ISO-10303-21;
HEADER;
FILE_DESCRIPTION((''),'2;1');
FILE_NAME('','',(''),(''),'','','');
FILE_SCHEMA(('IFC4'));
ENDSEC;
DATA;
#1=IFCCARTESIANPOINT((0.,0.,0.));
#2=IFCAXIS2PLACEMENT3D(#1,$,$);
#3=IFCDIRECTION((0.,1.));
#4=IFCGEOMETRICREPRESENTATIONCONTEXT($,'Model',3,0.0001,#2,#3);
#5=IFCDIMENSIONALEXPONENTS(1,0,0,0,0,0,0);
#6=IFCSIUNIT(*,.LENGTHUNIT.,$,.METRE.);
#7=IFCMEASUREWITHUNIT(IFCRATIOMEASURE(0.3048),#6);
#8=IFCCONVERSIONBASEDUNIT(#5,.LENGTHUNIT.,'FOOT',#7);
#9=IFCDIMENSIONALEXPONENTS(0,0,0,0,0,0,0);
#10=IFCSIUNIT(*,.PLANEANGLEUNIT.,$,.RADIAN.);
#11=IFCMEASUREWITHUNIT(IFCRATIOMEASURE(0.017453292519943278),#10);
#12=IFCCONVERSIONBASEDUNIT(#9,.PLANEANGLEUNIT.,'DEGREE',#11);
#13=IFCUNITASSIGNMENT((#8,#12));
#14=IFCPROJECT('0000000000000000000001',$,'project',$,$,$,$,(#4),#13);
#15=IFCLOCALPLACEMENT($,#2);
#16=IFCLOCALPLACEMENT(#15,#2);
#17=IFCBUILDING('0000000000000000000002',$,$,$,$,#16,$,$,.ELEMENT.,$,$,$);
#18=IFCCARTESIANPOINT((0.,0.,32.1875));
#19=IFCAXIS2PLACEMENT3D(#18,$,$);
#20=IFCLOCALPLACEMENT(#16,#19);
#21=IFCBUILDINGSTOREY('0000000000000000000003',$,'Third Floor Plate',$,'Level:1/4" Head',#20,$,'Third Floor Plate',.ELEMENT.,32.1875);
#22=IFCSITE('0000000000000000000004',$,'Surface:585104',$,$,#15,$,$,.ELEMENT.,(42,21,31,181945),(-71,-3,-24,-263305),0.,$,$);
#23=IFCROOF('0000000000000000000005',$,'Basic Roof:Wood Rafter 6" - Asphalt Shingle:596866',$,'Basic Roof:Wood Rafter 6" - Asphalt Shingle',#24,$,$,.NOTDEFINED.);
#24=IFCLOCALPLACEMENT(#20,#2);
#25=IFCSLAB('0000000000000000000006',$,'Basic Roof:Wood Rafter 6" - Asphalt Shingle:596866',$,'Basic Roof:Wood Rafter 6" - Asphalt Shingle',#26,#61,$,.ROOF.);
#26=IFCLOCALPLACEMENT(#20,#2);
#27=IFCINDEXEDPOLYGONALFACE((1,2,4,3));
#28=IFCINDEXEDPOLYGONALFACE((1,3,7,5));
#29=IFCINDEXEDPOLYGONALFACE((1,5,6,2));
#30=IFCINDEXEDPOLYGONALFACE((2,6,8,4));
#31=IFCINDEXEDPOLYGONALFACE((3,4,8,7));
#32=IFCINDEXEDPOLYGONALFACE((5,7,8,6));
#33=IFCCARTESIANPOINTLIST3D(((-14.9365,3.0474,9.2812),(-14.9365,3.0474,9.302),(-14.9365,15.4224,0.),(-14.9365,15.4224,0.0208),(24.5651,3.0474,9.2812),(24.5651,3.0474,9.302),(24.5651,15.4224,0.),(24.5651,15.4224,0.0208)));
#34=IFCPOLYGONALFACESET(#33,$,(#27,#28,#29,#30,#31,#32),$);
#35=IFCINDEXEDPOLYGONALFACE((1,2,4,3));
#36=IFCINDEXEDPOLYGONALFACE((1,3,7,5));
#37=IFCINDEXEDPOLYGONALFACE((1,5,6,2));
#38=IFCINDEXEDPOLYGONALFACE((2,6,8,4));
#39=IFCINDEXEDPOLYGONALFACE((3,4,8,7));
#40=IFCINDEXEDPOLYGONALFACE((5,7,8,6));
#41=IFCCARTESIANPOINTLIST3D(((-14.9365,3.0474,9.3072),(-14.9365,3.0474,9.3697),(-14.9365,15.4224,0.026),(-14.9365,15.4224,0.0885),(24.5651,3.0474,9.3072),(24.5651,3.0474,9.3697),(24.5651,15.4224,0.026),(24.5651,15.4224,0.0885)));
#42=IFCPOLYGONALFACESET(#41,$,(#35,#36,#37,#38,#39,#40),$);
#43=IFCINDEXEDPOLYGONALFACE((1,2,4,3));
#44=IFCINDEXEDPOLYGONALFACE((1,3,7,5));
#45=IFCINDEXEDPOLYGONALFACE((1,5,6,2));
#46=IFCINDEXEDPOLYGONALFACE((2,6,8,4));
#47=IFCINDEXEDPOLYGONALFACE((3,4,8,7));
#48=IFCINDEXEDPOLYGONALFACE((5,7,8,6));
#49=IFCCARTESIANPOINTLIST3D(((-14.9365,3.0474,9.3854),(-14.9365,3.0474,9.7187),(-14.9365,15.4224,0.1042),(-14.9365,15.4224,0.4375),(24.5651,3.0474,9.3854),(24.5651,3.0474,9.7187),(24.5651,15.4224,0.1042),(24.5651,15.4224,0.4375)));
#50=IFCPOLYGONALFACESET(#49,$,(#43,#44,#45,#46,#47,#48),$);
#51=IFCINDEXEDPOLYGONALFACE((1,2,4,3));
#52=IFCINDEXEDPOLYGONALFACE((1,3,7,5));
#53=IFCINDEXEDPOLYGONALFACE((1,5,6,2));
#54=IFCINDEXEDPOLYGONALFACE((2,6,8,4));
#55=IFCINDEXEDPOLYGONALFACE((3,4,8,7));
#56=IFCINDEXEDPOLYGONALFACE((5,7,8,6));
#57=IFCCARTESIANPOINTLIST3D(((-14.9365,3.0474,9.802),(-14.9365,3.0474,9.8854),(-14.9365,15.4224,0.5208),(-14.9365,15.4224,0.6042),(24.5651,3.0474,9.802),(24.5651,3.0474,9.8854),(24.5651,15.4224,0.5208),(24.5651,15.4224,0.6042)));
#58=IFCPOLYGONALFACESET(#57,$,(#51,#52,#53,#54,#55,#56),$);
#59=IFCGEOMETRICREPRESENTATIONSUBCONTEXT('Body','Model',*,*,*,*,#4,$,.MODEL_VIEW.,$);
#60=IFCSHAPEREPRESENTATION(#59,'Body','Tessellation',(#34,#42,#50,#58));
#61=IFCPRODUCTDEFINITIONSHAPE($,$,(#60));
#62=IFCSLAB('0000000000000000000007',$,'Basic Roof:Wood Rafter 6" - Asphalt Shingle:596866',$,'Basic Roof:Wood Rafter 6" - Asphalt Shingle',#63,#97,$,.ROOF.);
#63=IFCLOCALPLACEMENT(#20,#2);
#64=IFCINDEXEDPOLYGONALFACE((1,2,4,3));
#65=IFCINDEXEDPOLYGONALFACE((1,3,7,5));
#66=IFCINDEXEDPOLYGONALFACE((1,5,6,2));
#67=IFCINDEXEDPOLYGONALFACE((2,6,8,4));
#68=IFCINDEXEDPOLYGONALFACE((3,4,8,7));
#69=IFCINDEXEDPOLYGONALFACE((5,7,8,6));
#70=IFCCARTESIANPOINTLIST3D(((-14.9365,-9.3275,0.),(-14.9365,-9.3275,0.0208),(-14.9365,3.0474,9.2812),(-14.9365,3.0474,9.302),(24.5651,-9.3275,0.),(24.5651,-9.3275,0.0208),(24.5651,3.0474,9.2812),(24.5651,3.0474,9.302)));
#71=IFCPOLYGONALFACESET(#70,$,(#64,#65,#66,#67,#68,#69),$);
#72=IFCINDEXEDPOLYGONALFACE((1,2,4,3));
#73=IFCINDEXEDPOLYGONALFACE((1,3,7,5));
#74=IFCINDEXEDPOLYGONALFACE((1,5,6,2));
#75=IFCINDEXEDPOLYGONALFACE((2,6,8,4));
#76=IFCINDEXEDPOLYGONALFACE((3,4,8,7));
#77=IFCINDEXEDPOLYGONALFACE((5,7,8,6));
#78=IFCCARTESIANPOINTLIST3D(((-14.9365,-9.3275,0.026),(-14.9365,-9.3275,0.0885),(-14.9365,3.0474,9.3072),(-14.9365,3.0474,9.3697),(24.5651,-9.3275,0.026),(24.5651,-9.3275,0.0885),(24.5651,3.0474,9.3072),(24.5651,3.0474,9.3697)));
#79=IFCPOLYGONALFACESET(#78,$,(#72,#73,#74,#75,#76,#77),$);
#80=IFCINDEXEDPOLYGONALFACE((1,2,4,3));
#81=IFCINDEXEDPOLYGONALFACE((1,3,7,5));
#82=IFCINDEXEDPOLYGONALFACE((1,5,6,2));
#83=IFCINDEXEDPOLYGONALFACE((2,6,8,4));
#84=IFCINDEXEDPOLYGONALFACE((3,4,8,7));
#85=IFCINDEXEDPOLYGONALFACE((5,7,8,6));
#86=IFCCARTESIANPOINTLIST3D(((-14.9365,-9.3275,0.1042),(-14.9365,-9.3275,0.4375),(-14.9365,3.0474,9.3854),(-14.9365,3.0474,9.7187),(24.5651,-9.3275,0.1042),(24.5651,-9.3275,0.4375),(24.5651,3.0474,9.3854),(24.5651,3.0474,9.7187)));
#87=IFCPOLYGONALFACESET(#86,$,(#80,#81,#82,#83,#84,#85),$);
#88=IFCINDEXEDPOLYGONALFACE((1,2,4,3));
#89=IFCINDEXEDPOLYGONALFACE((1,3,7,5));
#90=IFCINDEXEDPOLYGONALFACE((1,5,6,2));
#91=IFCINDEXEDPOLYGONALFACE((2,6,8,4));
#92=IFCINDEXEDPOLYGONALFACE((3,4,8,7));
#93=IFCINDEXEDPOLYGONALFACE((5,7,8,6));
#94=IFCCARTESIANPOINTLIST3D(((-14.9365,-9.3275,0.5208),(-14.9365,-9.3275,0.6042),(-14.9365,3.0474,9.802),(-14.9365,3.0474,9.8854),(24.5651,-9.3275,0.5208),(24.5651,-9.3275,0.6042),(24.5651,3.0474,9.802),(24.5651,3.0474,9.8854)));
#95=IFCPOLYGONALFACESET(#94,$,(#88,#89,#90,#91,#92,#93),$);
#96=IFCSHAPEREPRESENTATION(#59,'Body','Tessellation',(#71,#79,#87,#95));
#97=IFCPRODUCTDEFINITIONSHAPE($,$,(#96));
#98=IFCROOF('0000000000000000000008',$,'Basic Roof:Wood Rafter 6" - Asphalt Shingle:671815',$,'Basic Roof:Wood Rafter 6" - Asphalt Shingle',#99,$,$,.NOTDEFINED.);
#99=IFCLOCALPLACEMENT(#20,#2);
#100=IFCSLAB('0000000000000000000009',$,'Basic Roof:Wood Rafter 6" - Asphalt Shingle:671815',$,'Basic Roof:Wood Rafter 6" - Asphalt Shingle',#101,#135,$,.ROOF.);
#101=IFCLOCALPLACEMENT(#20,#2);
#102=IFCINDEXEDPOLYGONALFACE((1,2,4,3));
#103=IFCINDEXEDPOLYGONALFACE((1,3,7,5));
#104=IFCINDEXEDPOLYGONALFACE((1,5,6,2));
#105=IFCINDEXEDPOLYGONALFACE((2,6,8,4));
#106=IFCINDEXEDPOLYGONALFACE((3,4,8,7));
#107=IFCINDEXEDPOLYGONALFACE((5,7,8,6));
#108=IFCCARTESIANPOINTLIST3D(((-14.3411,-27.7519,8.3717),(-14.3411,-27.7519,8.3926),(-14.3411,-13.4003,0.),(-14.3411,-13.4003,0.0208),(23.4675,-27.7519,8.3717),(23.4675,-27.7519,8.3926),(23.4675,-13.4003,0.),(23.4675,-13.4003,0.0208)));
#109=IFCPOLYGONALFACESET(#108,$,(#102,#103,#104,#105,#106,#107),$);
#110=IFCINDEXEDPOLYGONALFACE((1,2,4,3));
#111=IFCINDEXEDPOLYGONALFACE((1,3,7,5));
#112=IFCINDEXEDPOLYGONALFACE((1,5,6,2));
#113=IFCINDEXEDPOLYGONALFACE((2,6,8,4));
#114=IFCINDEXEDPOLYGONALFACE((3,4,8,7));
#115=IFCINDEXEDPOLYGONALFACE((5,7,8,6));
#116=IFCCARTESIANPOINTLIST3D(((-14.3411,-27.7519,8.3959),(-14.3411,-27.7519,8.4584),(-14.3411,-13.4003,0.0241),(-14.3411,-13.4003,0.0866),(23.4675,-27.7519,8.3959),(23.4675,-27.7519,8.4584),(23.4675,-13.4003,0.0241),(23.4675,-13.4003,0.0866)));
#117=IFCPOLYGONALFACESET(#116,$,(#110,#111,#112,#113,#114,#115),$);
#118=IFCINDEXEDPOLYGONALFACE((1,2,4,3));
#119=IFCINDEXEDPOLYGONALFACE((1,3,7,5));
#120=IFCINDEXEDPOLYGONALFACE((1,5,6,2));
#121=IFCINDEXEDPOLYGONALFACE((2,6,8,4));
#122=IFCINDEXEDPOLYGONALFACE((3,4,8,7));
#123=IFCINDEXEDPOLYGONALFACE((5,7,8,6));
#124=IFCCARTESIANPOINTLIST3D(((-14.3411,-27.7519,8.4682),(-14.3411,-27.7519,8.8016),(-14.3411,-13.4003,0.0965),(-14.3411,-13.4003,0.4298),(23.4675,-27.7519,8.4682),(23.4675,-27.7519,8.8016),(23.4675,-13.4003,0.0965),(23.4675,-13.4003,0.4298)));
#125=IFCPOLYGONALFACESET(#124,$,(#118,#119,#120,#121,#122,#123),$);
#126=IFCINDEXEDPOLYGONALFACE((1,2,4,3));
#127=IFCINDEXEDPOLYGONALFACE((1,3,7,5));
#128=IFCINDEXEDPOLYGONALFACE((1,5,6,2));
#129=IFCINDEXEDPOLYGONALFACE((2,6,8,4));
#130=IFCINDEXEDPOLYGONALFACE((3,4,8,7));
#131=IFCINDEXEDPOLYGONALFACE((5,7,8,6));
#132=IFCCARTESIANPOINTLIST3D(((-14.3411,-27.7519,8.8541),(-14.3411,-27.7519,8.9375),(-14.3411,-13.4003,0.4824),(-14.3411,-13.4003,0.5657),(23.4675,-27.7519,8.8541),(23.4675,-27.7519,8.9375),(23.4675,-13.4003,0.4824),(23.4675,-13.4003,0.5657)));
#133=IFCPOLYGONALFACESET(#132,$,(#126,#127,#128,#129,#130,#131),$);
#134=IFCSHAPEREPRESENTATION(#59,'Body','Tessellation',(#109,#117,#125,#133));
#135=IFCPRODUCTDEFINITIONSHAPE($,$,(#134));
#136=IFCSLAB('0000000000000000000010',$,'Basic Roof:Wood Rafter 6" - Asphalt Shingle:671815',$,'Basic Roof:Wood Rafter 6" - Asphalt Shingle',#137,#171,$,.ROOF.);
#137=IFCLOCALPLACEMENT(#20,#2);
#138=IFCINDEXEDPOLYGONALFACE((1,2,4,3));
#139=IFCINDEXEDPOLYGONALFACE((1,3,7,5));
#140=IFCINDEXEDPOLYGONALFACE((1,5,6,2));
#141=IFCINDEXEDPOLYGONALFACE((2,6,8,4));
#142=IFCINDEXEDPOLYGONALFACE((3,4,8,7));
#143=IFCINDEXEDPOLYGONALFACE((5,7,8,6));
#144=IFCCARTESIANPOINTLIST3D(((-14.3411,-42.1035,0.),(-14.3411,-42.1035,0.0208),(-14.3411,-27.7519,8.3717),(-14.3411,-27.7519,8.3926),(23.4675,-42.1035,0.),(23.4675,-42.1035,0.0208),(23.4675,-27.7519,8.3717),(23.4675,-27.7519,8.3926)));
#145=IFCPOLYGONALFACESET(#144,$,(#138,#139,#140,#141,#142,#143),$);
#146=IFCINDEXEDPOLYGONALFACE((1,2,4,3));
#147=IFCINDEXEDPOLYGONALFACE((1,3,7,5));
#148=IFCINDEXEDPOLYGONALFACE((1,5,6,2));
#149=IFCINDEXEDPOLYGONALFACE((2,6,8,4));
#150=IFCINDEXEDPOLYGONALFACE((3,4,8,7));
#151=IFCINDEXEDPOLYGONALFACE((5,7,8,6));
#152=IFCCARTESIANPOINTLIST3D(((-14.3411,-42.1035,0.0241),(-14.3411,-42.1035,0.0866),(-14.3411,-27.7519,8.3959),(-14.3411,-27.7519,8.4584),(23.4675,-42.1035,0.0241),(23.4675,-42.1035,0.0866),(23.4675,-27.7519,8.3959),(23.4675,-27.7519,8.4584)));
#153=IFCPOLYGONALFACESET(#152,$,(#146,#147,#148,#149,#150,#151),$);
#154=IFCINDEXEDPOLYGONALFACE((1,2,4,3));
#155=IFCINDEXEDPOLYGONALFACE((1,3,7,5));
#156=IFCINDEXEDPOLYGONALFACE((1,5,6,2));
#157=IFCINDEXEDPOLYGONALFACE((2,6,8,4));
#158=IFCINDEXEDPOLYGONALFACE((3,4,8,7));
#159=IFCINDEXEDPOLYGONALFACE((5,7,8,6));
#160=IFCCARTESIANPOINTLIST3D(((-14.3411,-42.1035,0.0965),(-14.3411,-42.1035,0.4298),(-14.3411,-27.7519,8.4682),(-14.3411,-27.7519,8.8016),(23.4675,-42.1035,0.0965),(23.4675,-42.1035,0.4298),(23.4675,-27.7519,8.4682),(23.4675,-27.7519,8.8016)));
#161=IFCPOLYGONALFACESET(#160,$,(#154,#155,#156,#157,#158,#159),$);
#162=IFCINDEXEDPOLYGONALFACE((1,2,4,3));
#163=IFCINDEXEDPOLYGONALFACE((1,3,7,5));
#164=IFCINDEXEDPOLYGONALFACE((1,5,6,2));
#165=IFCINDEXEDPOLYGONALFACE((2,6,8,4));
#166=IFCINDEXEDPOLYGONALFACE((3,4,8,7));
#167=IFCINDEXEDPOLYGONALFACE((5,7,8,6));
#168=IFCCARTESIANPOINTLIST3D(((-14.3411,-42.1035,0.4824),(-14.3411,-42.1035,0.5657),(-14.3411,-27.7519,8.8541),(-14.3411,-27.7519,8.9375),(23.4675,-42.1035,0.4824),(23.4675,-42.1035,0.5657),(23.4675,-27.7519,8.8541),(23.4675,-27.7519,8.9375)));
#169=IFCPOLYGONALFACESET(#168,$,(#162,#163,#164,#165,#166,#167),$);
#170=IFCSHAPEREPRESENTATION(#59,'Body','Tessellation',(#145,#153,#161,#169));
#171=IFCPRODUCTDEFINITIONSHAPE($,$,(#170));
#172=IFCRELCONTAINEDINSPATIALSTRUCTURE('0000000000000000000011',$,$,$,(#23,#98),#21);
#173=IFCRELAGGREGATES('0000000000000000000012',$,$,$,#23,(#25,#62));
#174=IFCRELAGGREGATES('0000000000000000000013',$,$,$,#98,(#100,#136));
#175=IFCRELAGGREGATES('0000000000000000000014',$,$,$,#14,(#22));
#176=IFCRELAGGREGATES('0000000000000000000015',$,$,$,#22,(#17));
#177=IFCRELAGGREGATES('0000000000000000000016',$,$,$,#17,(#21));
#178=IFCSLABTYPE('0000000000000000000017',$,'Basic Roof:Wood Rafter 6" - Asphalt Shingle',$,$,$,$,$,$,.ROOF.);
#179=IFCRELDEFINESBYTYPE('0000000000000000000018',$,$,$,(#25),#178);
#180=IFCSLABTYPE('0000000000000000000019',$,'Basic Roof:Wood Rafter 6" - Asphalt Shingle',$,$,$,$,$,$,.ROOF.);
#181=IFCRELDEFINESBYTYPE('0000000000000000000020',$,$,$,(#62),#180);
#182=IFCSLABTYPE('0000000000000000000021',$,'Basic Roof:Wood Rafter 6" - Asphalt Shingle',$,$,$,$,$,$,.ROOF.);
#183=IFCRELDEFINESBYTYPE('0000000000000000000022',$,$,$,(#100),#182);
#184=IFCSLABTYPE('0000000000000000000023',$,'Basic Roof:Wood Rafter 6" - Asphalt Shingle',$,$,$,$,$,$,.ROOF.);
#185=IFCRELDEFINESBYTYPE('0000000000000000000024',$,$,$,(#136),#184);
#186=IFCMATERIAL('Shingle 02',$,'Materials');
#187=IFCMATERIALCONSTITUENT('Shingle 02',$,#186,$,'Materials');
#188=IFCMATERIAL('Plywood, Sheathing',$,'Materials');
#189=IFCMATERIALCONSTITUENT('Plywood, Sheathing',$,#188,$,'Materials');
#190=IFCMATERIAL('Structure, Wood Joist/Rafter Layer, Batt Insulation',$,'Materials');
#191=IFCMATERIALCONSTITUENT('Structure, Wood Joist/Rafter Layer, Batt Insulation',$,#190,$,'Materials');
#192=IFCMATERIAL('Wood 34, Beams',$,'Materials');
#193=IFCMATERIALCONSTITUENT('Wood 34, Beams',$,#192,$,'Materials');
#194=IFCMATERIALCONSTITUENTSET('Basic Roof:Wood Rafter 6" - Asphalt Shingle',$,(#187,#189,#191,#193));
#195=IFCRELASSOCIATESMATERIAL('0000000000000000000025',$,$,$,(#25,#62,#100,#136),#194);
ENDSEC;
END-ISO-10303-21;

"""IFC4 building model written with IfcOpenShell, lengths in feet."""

from ifc_helpers import new_model, entity, si_unit, converted_unit, direction, frame, origin, place, context, subcontext, project, spatial, indexed_curve, outline, extrude, material, constituent, constituent_set, type_object, element, aggregate, save


model = new_model("IFC4")

# Units and contexts
model_context = context("Model", 3, precision=0.0001, world=origin(), true_north=direction((0.0, 1.0)))
body_context = subcontext(model_context, "Body", "Model", "MODEL_VIEW")
ifc_project = project(units=[converted_unit("LENGTHUNIT", "FOOT", entity("IfcRatioMeasure", 0.3048), si_unit("LENGTHUNIT", "METRE"), dimensions=[1, 0, 0, 0, 0, 0, 0]), converted_unit("PLANEANGLEUNIT", "DEGREE", entity("IfcRatioMeasure", 0.017453292519943278), si_unit("PLANEANGLEUNIT", "RADIAN"), dimensions=[0, 0, 0, 0, 0, 0, 0])], contexts=[model_context])

# Site, building, storey
site_placement = place(None, origin())
site = spatial("IfcSite", under=ifc_project, at=site_placement, Name="Surface:585104", CompositionType="ELEMENT", RefLatitude=(42, 21, 31, 181945), RefLongitude=(-71, -3, -24, -263305), RefElevation=0.0)
building_placement = place(site_placement, origin())
building = spatial("IfcBuilding", under=site, at=building_placement, CompositionType="ELEMENT")
storey_placement = place(building_placement, frame((0.0, 0.0, 32.1875)))
storey = spatial("IfcBuildingStorey", under=building, at=storey_placement, Name="Third Floor Plate", ObjectType="Level:1/4\" Head", LongName="Third Floor Plate", CompositionType="ELEMENT", Elevation=32.1875)

# Roofs, slabs
roof_1_placement = place(storey_placement, frame((-14.9365, -9.3275, 0.0)))
roof_1 = element("IfcRoof", 1, at=roof_1_placement, inside=storey, Name="Basic Roof:Wood Rafter 6\" - Asphalt Shingle:596866", ObjectType="Basic Roof:Wood Rafter 6\" - Asphalt Shingle", PredefinedType="NOTDEFINED")
ifc_material_1 = material(Name="Shingle 02", Category="Materials")
ifc_constituent_1 = constituent(ifc_material_1, Name="Shingle 02", Category="Materials")
ifc_material_2 = material(Name="Plywood, Sheathing", Category="Materials")
ifc_constituent_2 = constituent(ifc_material_2, Name="Plywood, Sheathing", Category="Materials")
ifc_material_3 = material(Name="Structure, Wood Joist/Rafter Layer, Batt Insulation", Category="Materials")
ifc_constituent_3 = constituent(ifc_material_3, Name="Structure, Wood Joist/Rafter Layer, Batt Insulation", Category="Materials")
ifc_material_4 = material(Name="Wood 34, Beams", Category="Materials")
ifc_constituent_4 = constituent(ifc_material_4, Name="Wood 34, Beams", Category="Materials")
ifc_constituent_set_1 = constituent_set(constituents=[ifc_constituent_1, ifc_constituent_2, ifc_constituent_3, ifc_constituent_4], Name="Basic Roof:Wood Rafter 6\" - Asphalt Shingle")
slab_type_1 = type_object("IfcSlabType", Name="Basic Roof:Wood Rafter 6\" - Asphalt Shingle", PredefinedType="ROOF")
slab_1_placement = place(roof_1_placement, origin())
slab_1 = element("IfcSlab", 2, at=slab_1_placement, type_object=slab_type_1, material=ifc_constituent_set_1, Name="Basic Roof:Wood Rafter 6\" - Asphalt Shingle:596866", ObjectType="Basic Roof:Wood Rafter 6\" - Asphalt Shingle", PredefinedType="ROOF", context=body_context, shape_type="SweptSolid", body=[
    extrude(outline(indexed_curve([(-19.7508, 7.7343), (-19.7508, -7.7343), (19.7508, -7.7343), (19.7508, 7.7343), (-19.7508, 7.7343)], self_intersect=False)), frame((19.7508, 18.5624, 4.6406), z_axis=(0.0, 0.6, 0.8), x_axis=(1.0, 0.0, 0.0)), (0.0, -0.6, 0.8), 0.0208),
    extrude(outline(indexed_curve([(-19.7508, 7.7343), (-19.7508, -7.7343), (19.7508, -7.7343), (19.7508, 7.7343), (-19.7508, 7.7343)], self_intersect=False)), frame((19.7508, 18.5624, 4.6666), z_axis=(0.0, 0.6, 0.8), x_axis=(1.0, 0.0, 0.0)), (0.0, -0.6, 0.8), 0.0625),
    extrude(outline(indexed_curve([(-19.7508, 7.7343), (-19.7508, -7.7343), (19.7508, -7.7343), (19.7508, 7.7343), (-19.7508, 7.7343)], self_intersect=False)), frame((19.7508, 18.5624, 4.7448), z_axis=(0.0, 0.6, 0.8), x_axis=(1.0, 0.0, 0.0)), (0.0, -0.6, 0.8), 0.3333),
    extrude(outline(indexed_curve([(-19.7508, 7.7343), (-19.7508, -7.7343), (19.7508, -7.7343), (19.7508, 7.7343), (-19.7508, 7.7343)], self_intersect=False)), frame((19.7508, 18.5624, 5.1614), z_axis=(0.0, 0.6, 0.8), x_axis=(1.0, 0.0, 0.0)), (0.0, -0.6, 0.8), 0.0833),
])
slab_type_2 = type_object("IfcSlabType", Name="Basic Roof:Wood Rafter 6\" - Asphalt Shingle", PredefinedType="ROOF")
slab_2_placement = place(roof_1_placement, origin())
slab_2 = element("IfcSlab", 3, at=slab_2_placement, type_object=slab_type_2, material=ifc_constituent_set_1, Name="Basic Roof:Wood Rafter 6\" - Asphalt Shingle:596866", ObjectType="Basic Roof:Wood Rafter 6\" - Asphalt Shingle", PredefinedType="ROOF", context=body_context, shape_type="SweptSolid", body=[
    extrude(outline(indexed_curve([(19.7508, 7.7343), (-19.7508, 7.7343), (-19.7508, -7.7343), (19.7508, -7.7343), (19.7508, 7.7343)], self_intersect=False)), frame((19.7508, 6.1875, 4.6406), z_axis=(0.0, -0.6, 0.8), x_axis=(1.0, 0.0, 0.0)), (0.0, 0.6, 0.8), 0.0208),
    extrude(outline(indexed_curve([(19.7508, 7.7343), (-19.7508, 7.7343), (-19.7508, -7.7343), (19.7508, -7.7343), (19.7508, 7.7343)], self_intersect=False)), frame((19.7508, 6.1875, 4.6666), z_axis=(0.0, -0.6, 0.8), x_axis=(1.0, 0.0, 0.0)), (0.0, 0.6, 0.8), 0.0625),
    extrude(outline(indexed_curve([(19.7508, 7.7343), (-19.7508, 7.7343), (-19.7508, -7.7343), (19.7508, -7.7343), (19.7508, 7.7343)], self_intersect=False)), frame((19.7508, 6.1875, 4.7448), z_axis=(0.0, -0.6, 0.8), x_axis=(1.0, 0.0, 0.0)), (0.0, 0.6, 0.8), 0.3333),
    extrude(outline(indexed_curve([(19.7508, 7.7343), (-19.7508, 7.7343), (-19.7508, -7.7343), (19.7508, -7.7343), (19.7508, 7.7343)], self_intersect=False)), frame((19.7508, 6.1875, 5.1614), z_axis=(0.0, -0.6, 0.8), x_axis=(1.0, 0.0, 0.0)), (0.0, 0.6, 0.8), 0.0833),
])
aggregate(roof_1, [slab_1, slab_2])
roof_2_placement = place(storey_placement, frame((-14.3411, -42.1035, 0.0)))
roof_2 = element("IfcRoof", 4, at=roof_2_placement, inside=storey, Name="Basic Roof:Wood Rafter 6\" - Asphalt Shingle:671815", ObjectType="Basic Roof:Wood Rafter 6\" - Asphalt Shingle", PredefinedType="NOTDEFINED")
slab_type_3 = type_object("IfcSlabType", Name="Basic Roof:Wood Rafter 6\" - Asphalt Shingle", PredefinedType="ROOF")
slab_3_placement = place(roof_2_placement, origin())
slab_3 = element("IfcSlab", 5, at=slab_3_placement, type_object=slab_type_3, material=ifc_constituent_set_1, Name="Basic Roof:Wood Rafter 6\" - Asphalt Shingle:671815", ObjectType="Basic Roof:Wood Rafter 6\" - Asphalt Shingle", PredefinedType="ROOF", context=body_context, shape_type="SweptSolid", body=[
    extrude(outline(indexed_curve([(-18.9043, 8.3074), (-18.9043, -8.3074), (18.9043, -8.3074), (18.9043, 8.3074), (-18.9043, 8.3074)], self_intersect=False)), frame((18.9043, 21.5273, 4.1859), z_axis=(0.0, 0.503871, 0.863779), x_axis=(1.0, 0.0, 0.0)), (0.0, -0.503871, 0.863779), 0.0208),
    extrude(outline(indexed_curve([(-18.9043, 8.3074), (-18.9043, -8.3074), (18.9043, -8.3074), (18.9043, 8.3074), (-18.9043, 8.3074)], self_intersect=False)), frame((18.9043, 21.5273, 4.21), z_axis=(0.0, 0.503871, 0.863779), x_axis=(1.0, 0.0, 0.0)), (0.0, -0.503871, 0.863779), 0.0625),
    extrude(outline(indexed_curve([(-18.9043, 8.3074), (-18.9043, -8.3074), (18.9043, -8.3074), (18.9043, 8.3074), (-18.9043, 8.3074)], self_intersect=False)), frame((18.9043, 21.5273, 4.2823), z_axis=(0.0, 0.503871, 0.863779), x_axis=(1.0, 0.0, 0.0)), (0.0, -0.503871, 0.863779), 0.3333),
    extrude(outline(indexed_curve([(-18.9043, 8.3074), (-18.9043, -8.3074), (18.9043, -8.3074), (18.9043, 8.3074), (-18.9043, 8.3074)], self_intersect=False)), frame((18.9043, 21.5273, 4.6682), z_axis=(0.0, 0.503871, 0.863779), x_axis=(1.0, 0.0, 0.0)), (0.0, -0.503871, 0.863779), 0.0833),
])
slab_type_4 = type_object("IfcSlabType", Name="Basic Roof:Wood Rafter 6\" - Asphalt Shingle", PredefinedType="ROOF")
slab_4_placement = place(roof_2_placement, origin())
slab_4 = element("IfcSlab", 6, at=slab_4_placement, type_object=slab_type_4, material=ifc_constituent_set_1, Name="Basic Roof:Wood Rafter 6\" - Asphalt Shingle:671815", ObjectType="Basic Roof:Wood Rafter 6\" - Asphalt Shingle", PredefinedType="ROOF", context=body_context, shape_type="SweptSolid", body=[
    extrude(outline(indexed_curve([(18.9043, 8.3074), (-18.9043, 8.3074), (-18.9043, -8.3074), (18.9043, -8.3074), (18.9043, 8.3074)], self_intersect=False)), frame((18.9043, 7.1758, 4.1859), z_axis=(0.0, -0.503871, 0.863779), x_axis=(1.0, 0.0, 0.0)), (0.0, 0.503871, 0.863779), 0.0208),
    extrude(outline(indexed_curve([(18.9043, 8.3074), (-18.9043, 8.3074), (-18.9043, -8.3074), (18.9043, -8.3074), (18.9043, 8.3074)], self_intersect=False)), frame((18.9043, 7.1758, 4.21), z_axis=(0.0, -0.503871, 0.863779), x_axis=(1.0, 0.0, 0.0)), (0.0, 0.503871, 0.863779), 0.0625),
    extrude(outline(indexed_curve([(18.9043, 8.3074), (-18.9043, 8.3074), (-18.9043, -8.3074), (18.9043, -8.3074), (18.9043, 8.3074)], self_intersect=False)), frame((18.9043, 7.1758, 4.2823), z_axis=(0.0, -0.503871, 0.863779), x_axis=(1.0, 0.0, 0.0)), (0.0, 0.503871, 0.863779), 0.3333),
    extrude(outline(indexed_curve([(18.9043, 8.3074), (-18.9043, 8.3074), (-18.9043, -8.3074), (18.9043, -8.3074), (18.9043, 8.3074)], self_intersect=False)), frame((18.9043, 7.1758, 4.6682), z_axis=(0.0, -0.503871, 0.863779), x_axis=(1.0, 0.0, 0.0)), (0.0, 0.503871, 0.863779), 0.0833),
])
aggregate(roof_2, [slab_3, slab_4])

save(model, "model.ifc")
